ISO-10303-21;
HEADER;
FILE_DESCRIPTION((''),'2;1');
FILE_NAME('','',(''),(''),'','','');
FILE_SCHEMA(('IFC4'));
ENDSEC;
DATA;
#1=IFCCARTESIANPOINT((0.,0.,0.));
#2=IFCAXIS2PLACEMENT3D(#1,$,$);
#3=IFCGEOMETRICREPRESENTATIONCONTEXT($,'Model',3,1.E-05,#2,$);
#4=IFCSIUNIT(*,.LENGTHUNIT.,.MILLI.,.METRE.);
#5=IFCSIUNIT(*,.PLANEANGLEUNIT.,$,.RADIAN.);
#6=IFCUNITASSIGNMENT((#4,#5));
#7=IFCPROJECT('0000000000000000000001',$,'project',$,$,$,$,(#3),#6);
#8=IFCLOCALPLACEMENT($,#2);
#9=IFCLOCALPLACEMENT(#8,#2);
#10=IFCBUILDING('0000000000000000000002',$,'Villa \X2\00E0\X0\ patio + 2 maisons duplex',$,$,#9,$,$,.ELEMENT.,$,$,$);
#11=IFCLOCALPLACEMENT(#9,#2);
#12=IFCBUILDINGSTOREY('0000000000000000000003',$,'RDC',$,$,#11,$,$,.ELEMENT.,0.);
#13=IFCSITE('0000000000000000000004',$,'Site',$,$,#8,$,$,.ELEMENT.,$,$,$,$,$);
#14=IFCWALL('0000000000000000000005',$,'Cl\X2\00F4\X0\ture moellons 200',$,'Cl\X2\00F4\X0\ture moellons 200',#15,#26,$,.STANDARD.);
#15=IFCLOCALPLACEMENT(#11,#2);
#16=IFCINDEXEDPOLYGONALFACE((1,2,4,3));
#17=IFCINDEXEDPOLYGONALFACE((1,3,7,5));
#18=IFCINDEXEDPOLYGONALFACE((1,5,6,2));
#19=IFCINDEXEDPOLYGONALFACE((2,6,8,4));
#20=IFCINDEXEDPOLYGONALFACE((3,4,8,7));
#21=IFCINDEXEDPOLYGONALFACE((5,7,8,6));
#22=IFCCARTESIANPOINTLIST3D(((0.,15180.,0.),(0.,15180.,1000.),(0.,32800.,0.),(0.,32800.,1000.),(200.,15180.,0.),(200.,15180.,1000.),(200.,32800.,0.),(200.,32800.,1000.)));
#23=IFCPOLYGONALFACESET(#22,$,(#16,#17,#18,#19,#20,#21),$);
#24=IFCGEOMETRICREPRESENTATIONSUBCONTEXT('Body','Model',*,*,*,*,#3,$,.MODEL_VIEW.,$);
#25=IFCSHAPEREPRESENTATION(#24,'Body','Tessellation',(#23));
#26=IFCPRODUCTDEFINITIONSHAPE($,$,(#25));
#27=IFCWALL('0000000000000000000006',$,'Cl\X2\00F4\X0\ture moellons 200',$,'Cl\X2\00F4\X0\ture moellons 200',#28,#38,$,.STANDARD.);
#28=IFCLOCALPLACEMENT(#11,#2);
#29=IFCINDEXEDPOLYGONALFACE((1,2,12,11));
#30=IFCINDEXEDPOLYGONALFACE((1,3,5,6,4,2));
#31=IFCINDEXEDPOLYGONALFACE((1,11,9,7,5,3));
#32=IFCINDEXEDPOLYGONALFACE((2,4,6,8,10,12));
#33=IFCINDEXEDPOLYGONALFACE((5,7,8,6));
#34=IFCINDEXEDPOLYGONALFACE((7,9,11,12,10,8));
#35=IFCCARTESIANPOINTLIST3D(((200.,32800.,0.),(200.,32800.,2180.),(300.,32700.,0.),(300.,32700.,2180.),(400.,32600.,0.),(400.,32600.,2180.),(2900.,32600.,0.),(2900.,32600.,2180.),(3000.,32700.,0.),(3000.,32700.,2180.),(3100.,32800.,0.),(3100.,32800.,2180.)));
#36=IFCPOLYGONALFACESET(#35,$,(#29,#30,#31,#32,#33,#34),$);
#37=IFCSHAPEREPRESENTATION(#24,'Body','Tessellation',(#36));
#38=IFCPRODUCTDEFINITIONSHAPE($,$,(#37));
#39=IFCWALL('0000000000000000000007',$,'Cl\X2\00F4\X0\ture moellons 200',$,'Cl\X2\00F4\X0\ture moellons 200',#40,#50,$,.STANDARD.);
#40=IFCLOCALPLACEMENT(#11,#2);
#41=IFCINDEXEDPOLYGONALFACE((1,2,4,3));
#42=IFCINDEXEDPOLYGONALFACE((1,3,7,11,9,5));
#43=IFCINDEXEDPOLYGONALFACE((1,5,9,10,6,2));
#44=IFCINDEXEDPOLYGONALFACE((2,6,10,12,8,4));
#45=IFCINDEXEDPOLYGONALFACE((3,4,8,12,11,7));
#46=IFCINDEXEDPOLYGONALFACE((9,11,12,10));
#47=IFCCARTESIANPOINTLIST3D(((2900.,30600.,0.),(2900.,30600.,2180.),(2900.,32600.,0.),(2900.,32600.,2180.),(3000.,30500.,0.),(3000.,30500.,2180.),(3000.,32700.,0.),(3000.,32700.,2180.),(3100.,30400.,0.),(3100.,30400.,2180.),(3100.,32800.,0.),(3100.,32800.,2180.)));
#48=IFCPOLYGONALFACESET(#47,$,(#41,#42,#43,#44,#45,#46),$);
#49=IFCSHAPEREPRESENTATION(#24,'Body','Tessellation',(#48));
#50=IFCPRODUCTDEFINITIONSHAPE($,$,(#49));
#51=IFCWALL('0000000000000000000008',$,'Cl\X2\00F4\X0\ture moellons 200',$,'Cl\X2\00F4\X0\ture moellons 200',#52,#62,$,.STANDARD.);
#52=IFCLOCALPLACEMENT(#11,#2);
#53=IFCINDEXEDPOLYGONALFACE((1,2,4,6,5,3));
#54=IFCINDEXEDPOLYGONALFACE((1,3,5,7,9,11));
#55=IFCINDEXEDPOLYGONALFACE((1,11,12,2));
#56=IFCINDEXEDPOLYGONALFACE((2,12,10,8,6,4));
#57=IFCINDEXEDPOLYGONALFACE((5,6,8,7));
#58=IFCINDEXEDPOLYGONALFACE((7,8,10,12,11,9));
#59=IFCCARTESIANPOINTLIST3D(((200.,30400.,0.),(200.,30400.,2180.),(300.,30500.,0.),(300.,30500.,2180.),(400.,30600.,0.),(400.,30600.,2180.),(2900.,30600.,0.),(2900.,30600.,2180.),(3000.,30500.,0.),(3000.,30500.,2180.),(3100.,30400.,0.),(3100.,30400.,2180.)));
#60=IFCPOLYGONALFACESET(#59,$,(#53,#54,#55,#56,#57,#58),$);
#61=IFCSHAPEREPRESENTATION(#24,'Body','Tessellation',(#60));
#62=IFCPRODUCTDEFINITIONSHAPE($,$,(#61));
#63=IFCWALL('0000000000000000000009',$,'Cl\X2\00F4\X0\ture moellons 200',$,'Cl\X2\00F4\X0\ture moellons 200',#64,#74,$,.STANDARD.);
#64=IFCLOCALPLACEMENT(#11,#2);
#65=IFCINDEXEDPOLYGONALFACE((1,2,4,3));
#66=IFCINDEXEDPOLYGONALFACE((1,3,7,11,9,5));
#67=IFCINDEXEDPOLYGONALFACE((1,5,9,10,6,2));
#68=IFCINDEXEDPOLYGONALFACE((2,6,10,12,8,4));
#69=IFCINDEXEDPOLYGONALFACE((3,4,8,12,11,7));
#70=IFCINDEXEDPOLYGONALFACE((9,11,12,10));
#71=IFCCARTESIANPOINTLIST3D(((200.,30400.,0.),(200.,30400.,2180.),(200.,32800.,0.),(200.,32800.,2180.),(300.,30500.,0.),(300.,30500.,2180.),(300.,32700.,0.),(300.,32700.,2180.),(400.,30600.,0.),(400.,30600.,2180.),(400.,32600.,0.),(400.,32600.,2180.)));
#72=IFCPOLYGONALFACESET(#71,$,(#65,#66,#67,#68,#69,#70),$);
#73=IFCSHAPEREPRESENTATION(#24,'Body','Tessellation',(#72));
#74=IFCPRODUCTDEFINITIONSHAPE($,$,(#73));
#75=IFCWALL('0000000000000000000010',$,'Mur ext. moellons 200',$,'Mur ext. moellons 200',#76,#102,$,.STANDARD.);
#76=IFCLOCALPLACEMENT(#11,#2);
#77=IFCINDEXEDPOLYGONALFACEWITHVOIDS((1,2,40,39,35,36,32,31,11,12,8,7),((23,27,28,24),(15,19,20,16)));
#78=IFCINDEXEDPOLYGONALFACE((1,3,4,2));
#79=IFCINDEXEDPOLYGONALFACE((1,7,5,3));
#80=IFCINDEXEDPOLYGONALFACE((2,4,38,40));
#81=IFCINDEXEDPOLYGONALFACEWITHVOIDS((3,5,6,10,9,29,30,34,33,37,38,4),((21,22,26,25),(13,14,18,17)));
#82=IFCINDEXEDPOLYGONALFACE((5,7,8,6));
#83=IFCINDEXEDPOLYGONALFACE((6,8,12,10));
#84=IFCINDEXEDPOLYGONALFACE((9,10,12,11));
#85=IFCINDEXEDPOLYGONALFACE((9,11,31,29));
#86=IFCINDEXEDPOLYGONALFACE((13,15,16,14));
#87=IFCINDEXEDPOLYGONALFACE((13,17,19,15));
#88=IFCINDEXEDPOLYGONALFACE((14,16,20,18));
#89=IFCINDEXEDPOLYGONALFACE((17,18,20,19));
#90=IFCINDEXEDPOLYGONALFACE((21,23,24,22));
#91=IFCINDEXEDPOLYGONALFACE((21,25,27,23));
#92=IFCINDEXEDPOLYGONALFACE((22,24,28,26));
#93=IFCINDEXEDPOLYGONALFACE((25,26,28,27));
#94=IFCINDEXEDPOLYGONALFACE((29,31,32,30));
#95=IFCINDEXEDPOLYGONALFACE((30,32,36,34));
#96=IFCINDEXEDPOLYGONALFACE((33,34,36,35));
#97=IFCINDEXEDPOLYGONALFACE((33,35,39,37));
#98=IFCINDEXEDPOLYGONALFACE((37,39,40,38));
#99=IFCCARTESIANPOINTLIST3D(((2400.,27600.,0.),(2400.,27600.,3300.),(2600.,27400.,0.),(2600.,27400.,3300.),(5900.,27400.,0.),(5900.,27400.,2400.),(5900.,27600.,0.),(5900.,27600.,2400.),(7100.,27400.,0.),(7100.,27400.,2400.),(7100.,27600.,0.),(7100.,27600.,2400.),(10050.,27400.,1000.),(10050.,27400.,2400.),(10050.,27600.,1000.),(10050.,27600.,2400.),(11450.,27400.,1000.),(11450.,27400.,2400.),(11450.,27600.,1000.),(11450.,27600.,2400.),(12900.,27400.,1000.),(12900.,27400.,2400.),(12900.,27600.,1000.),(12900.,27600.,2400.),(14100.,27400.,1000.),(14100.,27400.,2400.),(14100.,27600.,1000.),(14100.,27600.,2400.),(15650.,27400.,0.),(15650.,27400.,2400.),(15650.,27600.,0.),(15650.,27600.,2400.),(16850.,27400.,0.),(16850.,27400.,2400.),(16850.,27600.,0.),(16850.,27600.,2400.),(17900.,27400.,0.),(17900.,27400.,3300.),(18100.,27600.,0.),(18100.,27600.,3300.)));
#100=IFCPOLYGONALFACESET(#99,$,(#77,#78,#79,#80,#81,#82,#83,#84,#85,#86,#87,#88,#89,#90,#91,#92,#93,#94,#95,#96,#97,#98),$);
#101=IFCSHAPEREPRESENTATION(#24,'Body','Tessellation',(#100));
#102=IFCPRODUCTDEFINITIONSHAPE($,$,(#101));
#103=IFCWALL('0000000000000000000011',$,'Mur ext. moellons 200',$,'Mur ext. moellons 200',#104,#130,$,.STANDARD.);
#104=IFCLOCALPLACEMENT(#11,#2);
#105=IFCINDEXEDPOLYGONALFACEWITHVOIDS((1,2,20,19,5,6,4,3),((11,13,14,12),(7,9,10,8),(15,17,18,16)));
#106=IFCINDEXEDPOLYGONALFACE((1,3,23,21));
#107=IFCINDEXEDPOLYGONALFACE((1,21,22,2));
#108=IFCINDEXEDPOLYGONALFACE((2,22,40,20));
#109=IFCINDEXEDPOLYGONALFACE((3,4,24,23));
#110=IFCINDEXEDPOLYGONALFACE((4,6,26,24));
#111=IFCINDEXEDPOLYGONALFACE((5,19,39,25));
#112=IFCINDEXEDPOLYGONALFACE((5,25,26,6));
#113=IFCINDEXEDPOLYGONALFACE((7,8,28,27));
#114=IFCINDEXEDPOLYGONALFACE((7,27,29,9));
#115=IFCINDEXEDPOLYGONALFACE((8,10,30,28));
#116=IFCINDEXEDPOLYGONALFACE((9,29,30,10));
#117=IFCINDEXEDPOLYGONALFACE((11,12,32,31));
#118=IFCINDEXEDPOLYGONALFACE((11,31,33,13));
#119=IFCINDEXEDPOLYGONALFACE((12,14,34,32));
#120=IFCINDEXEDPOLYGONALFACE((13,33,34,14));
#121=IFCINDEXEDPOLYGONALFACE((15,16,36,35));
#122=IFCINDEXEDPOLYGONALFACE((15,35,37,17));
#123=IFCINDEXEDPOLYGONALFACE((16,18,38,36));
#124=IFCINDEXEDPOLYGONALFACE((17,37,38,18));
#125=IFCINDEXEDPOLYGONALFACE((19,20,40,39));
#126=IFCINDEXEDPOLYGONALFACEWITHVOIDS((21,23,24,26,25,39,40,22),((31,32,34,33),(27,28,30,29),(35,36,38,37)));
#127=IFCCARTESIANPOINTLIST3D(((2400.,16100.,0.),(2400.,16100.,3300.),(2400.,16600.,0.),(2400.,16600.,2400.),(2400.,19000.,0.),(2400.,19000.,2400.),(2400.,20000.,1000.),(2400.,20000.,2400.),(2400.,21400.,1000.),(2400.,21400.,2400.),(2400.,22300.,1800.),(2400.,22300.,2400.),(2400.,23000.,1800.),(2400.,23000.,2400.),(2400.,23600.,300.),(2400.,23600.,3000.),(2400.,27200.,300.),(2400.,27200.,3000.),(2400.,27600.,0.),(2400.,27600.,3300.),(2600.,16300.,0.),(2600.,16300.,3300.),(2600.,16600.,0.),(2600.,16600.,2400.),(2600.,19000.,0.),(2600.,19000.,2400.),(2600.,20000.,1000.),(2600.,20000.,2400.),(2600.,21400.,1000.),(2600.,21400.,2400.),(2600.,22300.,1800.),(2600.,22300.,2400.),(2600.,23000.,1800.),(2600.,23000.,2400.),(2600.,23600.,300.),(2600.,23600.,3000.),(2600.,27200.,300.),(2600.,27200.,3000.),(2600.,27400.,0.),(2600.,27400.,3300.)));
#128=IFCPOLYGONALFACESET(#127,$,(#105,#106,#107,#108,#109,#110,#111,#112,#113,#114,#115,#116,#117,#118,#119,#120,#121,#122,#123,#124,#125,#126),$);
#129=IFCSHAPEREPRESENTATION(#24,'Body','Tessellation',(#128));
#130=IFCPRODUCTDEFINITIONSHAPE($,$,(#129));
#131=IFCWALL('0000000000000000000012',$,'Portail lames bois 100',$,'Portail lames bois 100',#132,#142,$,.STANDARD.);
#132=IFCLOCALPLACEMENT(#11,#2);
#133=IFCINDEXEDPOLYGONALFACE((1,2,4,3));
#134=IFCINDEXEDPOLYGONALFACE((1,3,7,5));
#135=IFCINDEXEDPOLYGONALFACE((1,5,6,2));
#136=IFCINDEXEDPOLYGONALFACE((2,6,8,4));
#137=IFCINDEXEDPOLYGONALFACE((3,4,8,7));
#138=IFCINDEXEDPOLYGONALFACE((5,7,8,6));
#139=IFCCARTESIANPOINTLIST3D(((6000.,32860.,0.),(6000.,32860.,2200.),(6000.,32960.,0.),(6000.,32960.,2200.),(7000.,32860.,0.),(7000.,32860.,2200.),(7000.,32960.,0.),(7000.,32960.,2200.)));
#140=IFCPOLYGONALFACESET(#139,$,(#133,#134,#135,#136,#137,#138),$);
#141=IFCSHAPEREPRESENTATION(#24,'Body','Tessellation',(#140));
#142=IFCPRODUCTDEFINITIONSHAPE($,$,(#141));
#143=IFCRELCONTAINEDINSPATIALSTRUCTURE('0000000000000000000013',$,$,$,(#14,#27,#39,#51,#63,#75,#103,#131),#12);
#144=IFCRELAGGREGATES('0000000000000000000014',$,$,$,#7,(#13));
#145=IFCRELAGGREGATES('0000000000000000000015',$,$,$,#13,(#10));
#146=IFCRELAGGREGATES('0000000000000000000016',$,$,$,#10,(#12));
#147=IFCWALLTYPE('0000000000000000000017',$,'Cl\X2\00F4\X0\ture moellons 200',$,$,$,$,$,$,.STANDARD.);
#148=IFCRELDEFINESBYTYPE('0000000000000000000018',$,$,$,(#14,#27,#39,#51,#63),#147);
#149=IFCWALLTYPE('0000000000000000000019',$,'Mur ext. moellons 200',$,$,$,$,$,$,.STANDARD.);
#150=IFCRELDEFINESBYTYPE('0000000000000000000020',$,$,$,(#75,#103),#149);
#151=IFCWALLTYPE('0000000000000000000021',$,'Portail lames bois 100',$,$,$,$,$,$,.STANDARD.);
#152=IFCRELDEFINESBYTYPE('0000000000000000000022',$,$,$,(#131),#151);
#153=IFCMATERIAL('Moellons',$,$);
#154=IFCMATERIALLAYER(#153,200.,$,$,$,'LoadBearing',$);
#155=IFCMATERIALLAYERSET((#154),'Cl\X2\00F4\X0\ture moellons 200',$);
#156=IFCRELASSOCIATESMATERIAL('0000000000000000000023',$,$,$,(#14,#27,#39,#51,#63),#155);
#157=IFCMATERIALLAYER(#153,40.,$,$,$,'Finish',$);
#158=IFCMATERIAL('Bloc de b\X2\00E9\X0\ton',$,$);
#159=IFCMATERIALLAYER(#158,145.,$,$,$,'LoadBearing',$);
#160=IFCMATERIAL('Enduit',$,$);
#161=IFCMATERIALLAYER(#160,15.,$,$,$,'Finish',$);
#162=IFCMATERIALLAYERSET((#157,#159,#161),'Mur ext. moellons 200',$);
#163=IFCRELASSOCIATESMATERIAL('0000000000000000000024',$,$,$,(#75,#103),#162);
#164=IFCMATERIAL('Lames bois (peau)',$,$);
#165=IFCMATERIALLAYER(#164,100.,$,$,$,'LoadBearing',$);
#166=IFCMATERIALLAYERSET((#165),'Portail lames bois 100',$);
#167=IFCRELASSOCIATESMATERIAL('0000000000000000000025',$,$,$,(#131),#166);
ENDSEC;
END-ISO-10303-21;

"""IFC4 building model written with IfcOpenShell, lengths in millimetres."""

from ifc_helpers import new_model, si_unit, frame, frame_2d, origin, place, context, subcontext, project, spatial, polyline, rectangle, outline, extrude, material, layer, layer_set, layer_usage, type_object, element, save


model = new_model("IFC4")

# Units and contexts
model_context = context("Model", 3, precision=1e-05, world=origin())
body_context = subcontext(model_context, "Body", "Model", "MODEL_VIEW")
ifc_project = project(units=[si_unit("LENGTHUNIT", "METRE", prefix="MILLI"), si_unit("PLANEANGLEUNIT", "RADIAN")], contexts=[model_context])

# Site, building, storey
site_placement = place(None, origin())
site = spatial("IfcSite", under=ifc_project, at=site_placement, Name="Site", CompositionType="ELEMENT")
building_placement = place(site_placement, origin())
building = spatial("IfcBuilding", under=site, at=building_placement, Name="Villa à patio + 2 maisons duplex", CompositionType="ELEMENT")
storey_placement = place(building_placement, origin())
storey = spatial("IfcBuildingStorey", under=building, at=storey_placement, Name="RDC", CompositionType="ELEMENT", Elevation=0.0)

# Shared definitions
ifc_material_1 = material(Name="Enduit")
ifc_material_2 = material(Name="Bloc de béton")

# Shared definitions
ifc_material_3 = material(Name="Moellons")
ifc_layer_1 = layer(ifc_material_3, 200.0, Category="LoadBearing")
ifc_layer_set_1 = layer_set([ifc_layer_1], Name="Clôture moellons 200")
ifc_layer_usage_1 = layer_usage(ifc_layer_set_1, "AXIS2", "NEGATIVE", 100.0)
wall_type_1 = type_object("IfcWallType", Name="Clôture moellons 200", PredefinedType="STANDARD")

# Walls
wall_1_placement = place(storey_placement, frame((100.0, 32800.0, 0.0), z_axis=(0.0, 0.0, 1.0), x_axis=(0.0, -1.0, 0.0)))
element("IfcWall", 1, at=wall_1_placement, inside=storey, type_object=wall_type_1, material=ifc_layer_usage_1, Name="Clôture moellons 200", ObjectType="Clôture moellons 200", PredefinedType="STANDARD", context=body_context, shape_type="SweptSolid", body=[
    extrude(outline(polyline([(0.0, -100.0), (0.0, 100.0), (17620.0, 100.0), (17620.0, -100.0), (0.0, -100.0)])), origin(), (0.0, 0.0, 1.0), 1000.0),
])
wall_2_placement = place(storey_placement, frame((300.0, 32700.0, 0.0), z_axis=(0.0, 0.0, 1.0), x_axis=(1.0, 0.0, 0.0)))
element("IfcWall", 2, at=wall_2_placement, inside=storey, type_object=wall_type_1, material=ifc_layer_usage_1, Name="Clôture moellons 200", ObjectType="Clôture moellons 200", PredefinedType="STANDARD", context=body_context, shape_type="SweptSolid", body=[
    extrude(outline(polyline([(100.0, -100.0), (0.0, 0.0), (-100.0, 100.0), (2800.0, 100.0), (2700.0, 0.0), (2600.0, -100.0), (100.0, -100.0)])), origin(), (0.0, 0.0, 1.0), 2180.0),
])
wall_3_placement = place(storey_placement, frame((3000.0, 32700.0, 0.0), z_axis=(0.0, 0.0, 1.0), x_axis=(0.0, -1.0, 0.0)))
element("IfcWall", 3, at=wall_3_placement, inside=storey, type_object=wall_type_1, material=ifc_layer_usage_1, Name="Clôture moellons 200", ObjectType="Clôture moellons 200", PredefinedType="STANDARD", context=body_context, shape_type="SweptSolid", body=[
    extrude(outline(polyline([(100.0, -100.0), (0.0, 0.0), (-100.0, 100.0), (2300.0, 100.0), (2200.0, 0.0), (2100.0, -100.0), (100.0, -100.0)])), origin(), (0.0, 0.0, 1.0), 2180.0),
])
wall_4_placement = place(storey_placement, frame((3000.0, 30500.0, 0.0), z_axis=(0.0, 0.0, 1.0), x_axis=(-1.0, 0.0, 0.0)))
element("IfcWall", 4, at=wall_4_placement, inside=storey, type_object=wall_type_1, material=ifc_layer_usage_1, Name="Clôture moellons 200", ObjectType="Clôture moellons 200", PredefinedType="STANDARD", context=body_context, shape_type="SweptSolid", body=[
    extrude(outline(polyline([(100.0, -100.0), (0.0, 0.0), (-100.0, 100.0), (2800.0, 100.0), (2700.0, 0.0), (2600.0, -100.0), (100.0, -100.0)])), origin(), (0.0, 0.0, 1.0), 2180.0),
])
wall_5_placement = place(storey_placement, frame((300.0, 30500.0, 0.0), z_axis=(0.0, 0.0, 1.0), x_axis=(0.0, 1.0, 0.0)))
element("IfcWall", 5, at=wall_5_placement, inside=storey, type_object=wall_type_1, material=ifc_layer_usage_1, Name="Clôture moellons 200", ObjectType="Clôture moellons 200", PredefinedType="STANDARD", context=body_context, shape_type="SweptSolid", body=[
    extrude(outline(polyline([(100.0, -100.0), (0.0, 0.0), (-100.0, 100.0), (2300.0, 100.0), (2200.0, 0.0), (2100.0, -100.0), (100.0, -100.0)])), origin(), (0.0, 0.0, 1.0), 2180.0),
])

# Walls, openings
ifc_layer_2 = layer(ifc_material_3, 40.0, Category="Finish")
ifc_layer_3 = layer(ifc_material_2, 145.0, Category="LoadBearing")
ifc_layer_4 = layer(ifc_material_1, 15.0, Category="Finish")
ifc_layer_set_2 = layer_set([ifc_layer_2, ifc_layer_3, ifc_layer_4], Name="Mur ext. moellons 200")
ifc_layer_usage_2 = layer_usage(ifc_layer_set_2, "AXIS2", "NEGATIVE", 100.0)
wall_type_2 = type_object("IfcWallType", Name="Mur ext. moellons 200", PredefinedType="STANDARD")
wall_6_placement = place(storey_placement, frame((2500.0, 27500.0, 0.0), z_axis=(0.0, 0.0, 1.0), x_axis=(1.0, 0.0, 0.0)))
wall_6 = element("IfcWall", 6, at=wall_6_placement, inside=storey, type_object=wall_type_2, material=ifc_layer_usage_2, Name="Mur ext. moellons 200", ObjectType="Mur ext. moellons 200", PredefinedType="STANDARD", context=body_context, shape_type="SweptSolid", body=[
    extrude(outline(polyline([(100.0, -100.0), (0.0, 0.0), (-100.0, 100.0), (15600.0, 100.0), (15500.0, 0.0), (15400.0, -100.0), (100.0, -100.0)])), origin(), (0.0, 0.0, 1.0), 3300.0),
])
opening_1_placement = place(wall_6_placement, frame((3400.0, 0.0, 0.0), z_axis=(0.0, 0.0, 1.0), x_axis=(1.0, 0.0, 0.0)))
element("IfcOpeningElement", 7, at=opening_1_placement, cuts=wall_6, PredefinedType="OPENING", context=body_context, shape_type="SweptSolid", body=[
    extrude(rectangle(XDim=1200.0, YDim=220.0, at=frame_2d((600.0, 0.0))), origin(), (0.0, 0.0, 1.0), 2400.0),
])
opening_2_placement = place(wall_6_placement, frame((7550.0, 0.0, 1000.0), z_axis=(0.0, 0.0, 1.0), x_axis=(1.0, 0.0, 0.0)))
element("IfcOpeningElement", 8, at=opening_2_placement, cuts=wall_6, PredefinedType="OPENING", context=body_context, shape_type="SweptSolid", body=[
    extrude(rectangle(XDim=1400.0, YDim=220.0, at=frame_2d((700.0, 0.0))), origin(), (0.0, 0.0, 1.0), 1400.0),
])
opening_3_placement = place(wall_6_placement, frame((10400.0, 0.0, 1000.0), z_axis=(0.0, 0.0, 1.0), x_axis=(1.0, 0.0, 0.0)))
element("IfcOpeningElement", 9, at=opening_3_placement, cuts=wall_6, PredefinedType="OPENING", context=body_context, shape_type="SweptSolid", body=[
    extrude(rectangle(XDim=1200.0, YDim=220.0, at=frame_2d((600.0, 0.0))), origin(), (0.0, 0.0, 1.0), 1400.0),
])
opening_4_placement = place(wall_6_placement, frame((13150.0, 0.0, 0.0), z_axis=(0.0, 0.0, 1.0), x_axis=(1.0, 0.0, 0.0)))
element("IfcOpeningElement", 10, at=opening_4_placement, cuts=wall_6, PredefinedType="OPENING", context=body_context, shape_type="SweptSolid", body=[
    extrude(rectangle(XDim=1200.0, YDim=220.0, at=frame_2d((600.0, 0.0))), origin(), (0.0, 0.0, 1.0), 2400.0),
])
wall_7_placement = place(storey_placement, frame((2500.0, 27500.0, 0.0), z_axis=(0.0, 0.0, 1.0), x_axis=(0.0, -1.0, 0.0)))
wall_7 = element("IfcWall", 11, at=wall_7_placement, inside=storey, type_object=wall_type_2, material=ifc_layer_usage_2, Name="Mur ext. moellons 200", ObjectType="Mur ext. moellons 200", PredefinedType="STANDARD", context=body_context, shape_type="SweptSolid", body=[
    extrude(outline(polyline([(-100.0, -100.0), (0.0, 0.0), (100.0, 100.0), (11200.0, 100.0), (11300.0, 0.0), (11400.0, -100.0), (-100.0, -100.0)])), origin(), (0.0, 0.0, 1.0), 3300.0),
])
opening_5_placement = place(wall_7_placement, frame((300.0, 0.0, 300.0), z_axis=(0.0, 0.0, 1.0), x_axis=(1.0, 0.0, 0.0)))
element("IfcOpeningElement", 12, at=opening_5_placement, cuts=wall_7, PredefinedType="OPENING", context=body_context, shape_type="SweptSolid", body=[
    extrude(rectangle(XDim=3600.0, YDim=220.0, at=frame_2d((1800.0, 0.0))), origin(), (0.0, 0.0, 1.0), 2700.0),
])
opening_6_placement = place(wall_7_placement, frame((4500.0, 0.0, 1800.0), z_axis=(0.0, 0.0, 1.0), x_axis=(1.0, 0.0, 0.0)))
element("IfcOpeningElement", 13, at=opening_6_placement, cuts=wall_7, PredefinedType="OPENING", context=body_context, shape_type="SweptSolid", body=[
    extrude(rectangle(XDim=700.0, YDim=220.0, at=frame_2d((350.0, 0.0))), origin(), (0.0, 0.0, 1.0), 600.0),
])
opening_7_placement = place(wall_7_placement, frame((6100.0, 0.0, 1000.0), z_axis=(0.0, 0.0, 1.0), x_axis=(1.0, 0.0, 0.0)))
element("IfcOpeningElement", 14, at=opening_7_placement, cuts=wall_7, PredefinedType="OPENING", context=body_context, shape_type="SweptSolid", body=[
    extrude(rectangle(XDim=1400.0, YDim=220.0, at=frame_2d((700.0, 0.0))), origin(), (0.0, 0.0, 1.0), 1400.0),
])
opening_8_placement = place(wall_7_placement, frame((8500.0, 0.0, 0.0), z_axis=(0.0, 0.0, 1.0), x_axis=(1.0, 0.0, 0.0)))
element("IfcOpeningElement", 15, at=opening_8_placement, cuts=wall_7, PredefinedType="OPENING", context=body_context, shape_type="SweptSolid", body=[
    extrude(rectangle(XDim=2400.0, YDim=220.0, at=frame_2d((1200.0, 0.0))), origin(), (0.0, 0.0, 1.0), 2400.0),
])

# Wall
ifc_material_4 = material(Name="Lames bois (peau)")
ifc_layer_5 = layer(ifc_material_4, 100.0, Category="LoadBearing")
ifc_layer_set_3 = layer_set([ifc_layer_5], Name="Portail lames bois 100")
ifc_layer_usage_3 = layer_usage(ifc_layer_set_3, "AXIS2", "NEGATIVE", 50.0)
wall_type_3 = type_object("IfcWallType", Name="Portail lames bois 100", PredefinedType="STANDARD")
wall_8_placement = place(storey_placement, frame((6000.0, 32910.0, 0.0), z_axis=(0.0, 0.0, 1.0), x_axis=(1.0, 0.0, 0.0)))
element("IfcWall", 16, at=wall_8_placement, inside=storey, type_object=wall_type_3, material=ifc_layer_usage_3, Name="Portail lames bois 100", ObjectType="Portail lames bois 100", PredefinedType="STANDARD", context=body_context, shape_type="SweptSolid", body=[
    extrude(outline(polyline([(0.0, -50.0), (0.0, 50.0), (1000.0, 50.0), (1000.0, -50.0), (0.0, -50.0)])), origin(), (0.0, 0.0, 1.0), 2200.0),
])

save(model, "model.ifc")
